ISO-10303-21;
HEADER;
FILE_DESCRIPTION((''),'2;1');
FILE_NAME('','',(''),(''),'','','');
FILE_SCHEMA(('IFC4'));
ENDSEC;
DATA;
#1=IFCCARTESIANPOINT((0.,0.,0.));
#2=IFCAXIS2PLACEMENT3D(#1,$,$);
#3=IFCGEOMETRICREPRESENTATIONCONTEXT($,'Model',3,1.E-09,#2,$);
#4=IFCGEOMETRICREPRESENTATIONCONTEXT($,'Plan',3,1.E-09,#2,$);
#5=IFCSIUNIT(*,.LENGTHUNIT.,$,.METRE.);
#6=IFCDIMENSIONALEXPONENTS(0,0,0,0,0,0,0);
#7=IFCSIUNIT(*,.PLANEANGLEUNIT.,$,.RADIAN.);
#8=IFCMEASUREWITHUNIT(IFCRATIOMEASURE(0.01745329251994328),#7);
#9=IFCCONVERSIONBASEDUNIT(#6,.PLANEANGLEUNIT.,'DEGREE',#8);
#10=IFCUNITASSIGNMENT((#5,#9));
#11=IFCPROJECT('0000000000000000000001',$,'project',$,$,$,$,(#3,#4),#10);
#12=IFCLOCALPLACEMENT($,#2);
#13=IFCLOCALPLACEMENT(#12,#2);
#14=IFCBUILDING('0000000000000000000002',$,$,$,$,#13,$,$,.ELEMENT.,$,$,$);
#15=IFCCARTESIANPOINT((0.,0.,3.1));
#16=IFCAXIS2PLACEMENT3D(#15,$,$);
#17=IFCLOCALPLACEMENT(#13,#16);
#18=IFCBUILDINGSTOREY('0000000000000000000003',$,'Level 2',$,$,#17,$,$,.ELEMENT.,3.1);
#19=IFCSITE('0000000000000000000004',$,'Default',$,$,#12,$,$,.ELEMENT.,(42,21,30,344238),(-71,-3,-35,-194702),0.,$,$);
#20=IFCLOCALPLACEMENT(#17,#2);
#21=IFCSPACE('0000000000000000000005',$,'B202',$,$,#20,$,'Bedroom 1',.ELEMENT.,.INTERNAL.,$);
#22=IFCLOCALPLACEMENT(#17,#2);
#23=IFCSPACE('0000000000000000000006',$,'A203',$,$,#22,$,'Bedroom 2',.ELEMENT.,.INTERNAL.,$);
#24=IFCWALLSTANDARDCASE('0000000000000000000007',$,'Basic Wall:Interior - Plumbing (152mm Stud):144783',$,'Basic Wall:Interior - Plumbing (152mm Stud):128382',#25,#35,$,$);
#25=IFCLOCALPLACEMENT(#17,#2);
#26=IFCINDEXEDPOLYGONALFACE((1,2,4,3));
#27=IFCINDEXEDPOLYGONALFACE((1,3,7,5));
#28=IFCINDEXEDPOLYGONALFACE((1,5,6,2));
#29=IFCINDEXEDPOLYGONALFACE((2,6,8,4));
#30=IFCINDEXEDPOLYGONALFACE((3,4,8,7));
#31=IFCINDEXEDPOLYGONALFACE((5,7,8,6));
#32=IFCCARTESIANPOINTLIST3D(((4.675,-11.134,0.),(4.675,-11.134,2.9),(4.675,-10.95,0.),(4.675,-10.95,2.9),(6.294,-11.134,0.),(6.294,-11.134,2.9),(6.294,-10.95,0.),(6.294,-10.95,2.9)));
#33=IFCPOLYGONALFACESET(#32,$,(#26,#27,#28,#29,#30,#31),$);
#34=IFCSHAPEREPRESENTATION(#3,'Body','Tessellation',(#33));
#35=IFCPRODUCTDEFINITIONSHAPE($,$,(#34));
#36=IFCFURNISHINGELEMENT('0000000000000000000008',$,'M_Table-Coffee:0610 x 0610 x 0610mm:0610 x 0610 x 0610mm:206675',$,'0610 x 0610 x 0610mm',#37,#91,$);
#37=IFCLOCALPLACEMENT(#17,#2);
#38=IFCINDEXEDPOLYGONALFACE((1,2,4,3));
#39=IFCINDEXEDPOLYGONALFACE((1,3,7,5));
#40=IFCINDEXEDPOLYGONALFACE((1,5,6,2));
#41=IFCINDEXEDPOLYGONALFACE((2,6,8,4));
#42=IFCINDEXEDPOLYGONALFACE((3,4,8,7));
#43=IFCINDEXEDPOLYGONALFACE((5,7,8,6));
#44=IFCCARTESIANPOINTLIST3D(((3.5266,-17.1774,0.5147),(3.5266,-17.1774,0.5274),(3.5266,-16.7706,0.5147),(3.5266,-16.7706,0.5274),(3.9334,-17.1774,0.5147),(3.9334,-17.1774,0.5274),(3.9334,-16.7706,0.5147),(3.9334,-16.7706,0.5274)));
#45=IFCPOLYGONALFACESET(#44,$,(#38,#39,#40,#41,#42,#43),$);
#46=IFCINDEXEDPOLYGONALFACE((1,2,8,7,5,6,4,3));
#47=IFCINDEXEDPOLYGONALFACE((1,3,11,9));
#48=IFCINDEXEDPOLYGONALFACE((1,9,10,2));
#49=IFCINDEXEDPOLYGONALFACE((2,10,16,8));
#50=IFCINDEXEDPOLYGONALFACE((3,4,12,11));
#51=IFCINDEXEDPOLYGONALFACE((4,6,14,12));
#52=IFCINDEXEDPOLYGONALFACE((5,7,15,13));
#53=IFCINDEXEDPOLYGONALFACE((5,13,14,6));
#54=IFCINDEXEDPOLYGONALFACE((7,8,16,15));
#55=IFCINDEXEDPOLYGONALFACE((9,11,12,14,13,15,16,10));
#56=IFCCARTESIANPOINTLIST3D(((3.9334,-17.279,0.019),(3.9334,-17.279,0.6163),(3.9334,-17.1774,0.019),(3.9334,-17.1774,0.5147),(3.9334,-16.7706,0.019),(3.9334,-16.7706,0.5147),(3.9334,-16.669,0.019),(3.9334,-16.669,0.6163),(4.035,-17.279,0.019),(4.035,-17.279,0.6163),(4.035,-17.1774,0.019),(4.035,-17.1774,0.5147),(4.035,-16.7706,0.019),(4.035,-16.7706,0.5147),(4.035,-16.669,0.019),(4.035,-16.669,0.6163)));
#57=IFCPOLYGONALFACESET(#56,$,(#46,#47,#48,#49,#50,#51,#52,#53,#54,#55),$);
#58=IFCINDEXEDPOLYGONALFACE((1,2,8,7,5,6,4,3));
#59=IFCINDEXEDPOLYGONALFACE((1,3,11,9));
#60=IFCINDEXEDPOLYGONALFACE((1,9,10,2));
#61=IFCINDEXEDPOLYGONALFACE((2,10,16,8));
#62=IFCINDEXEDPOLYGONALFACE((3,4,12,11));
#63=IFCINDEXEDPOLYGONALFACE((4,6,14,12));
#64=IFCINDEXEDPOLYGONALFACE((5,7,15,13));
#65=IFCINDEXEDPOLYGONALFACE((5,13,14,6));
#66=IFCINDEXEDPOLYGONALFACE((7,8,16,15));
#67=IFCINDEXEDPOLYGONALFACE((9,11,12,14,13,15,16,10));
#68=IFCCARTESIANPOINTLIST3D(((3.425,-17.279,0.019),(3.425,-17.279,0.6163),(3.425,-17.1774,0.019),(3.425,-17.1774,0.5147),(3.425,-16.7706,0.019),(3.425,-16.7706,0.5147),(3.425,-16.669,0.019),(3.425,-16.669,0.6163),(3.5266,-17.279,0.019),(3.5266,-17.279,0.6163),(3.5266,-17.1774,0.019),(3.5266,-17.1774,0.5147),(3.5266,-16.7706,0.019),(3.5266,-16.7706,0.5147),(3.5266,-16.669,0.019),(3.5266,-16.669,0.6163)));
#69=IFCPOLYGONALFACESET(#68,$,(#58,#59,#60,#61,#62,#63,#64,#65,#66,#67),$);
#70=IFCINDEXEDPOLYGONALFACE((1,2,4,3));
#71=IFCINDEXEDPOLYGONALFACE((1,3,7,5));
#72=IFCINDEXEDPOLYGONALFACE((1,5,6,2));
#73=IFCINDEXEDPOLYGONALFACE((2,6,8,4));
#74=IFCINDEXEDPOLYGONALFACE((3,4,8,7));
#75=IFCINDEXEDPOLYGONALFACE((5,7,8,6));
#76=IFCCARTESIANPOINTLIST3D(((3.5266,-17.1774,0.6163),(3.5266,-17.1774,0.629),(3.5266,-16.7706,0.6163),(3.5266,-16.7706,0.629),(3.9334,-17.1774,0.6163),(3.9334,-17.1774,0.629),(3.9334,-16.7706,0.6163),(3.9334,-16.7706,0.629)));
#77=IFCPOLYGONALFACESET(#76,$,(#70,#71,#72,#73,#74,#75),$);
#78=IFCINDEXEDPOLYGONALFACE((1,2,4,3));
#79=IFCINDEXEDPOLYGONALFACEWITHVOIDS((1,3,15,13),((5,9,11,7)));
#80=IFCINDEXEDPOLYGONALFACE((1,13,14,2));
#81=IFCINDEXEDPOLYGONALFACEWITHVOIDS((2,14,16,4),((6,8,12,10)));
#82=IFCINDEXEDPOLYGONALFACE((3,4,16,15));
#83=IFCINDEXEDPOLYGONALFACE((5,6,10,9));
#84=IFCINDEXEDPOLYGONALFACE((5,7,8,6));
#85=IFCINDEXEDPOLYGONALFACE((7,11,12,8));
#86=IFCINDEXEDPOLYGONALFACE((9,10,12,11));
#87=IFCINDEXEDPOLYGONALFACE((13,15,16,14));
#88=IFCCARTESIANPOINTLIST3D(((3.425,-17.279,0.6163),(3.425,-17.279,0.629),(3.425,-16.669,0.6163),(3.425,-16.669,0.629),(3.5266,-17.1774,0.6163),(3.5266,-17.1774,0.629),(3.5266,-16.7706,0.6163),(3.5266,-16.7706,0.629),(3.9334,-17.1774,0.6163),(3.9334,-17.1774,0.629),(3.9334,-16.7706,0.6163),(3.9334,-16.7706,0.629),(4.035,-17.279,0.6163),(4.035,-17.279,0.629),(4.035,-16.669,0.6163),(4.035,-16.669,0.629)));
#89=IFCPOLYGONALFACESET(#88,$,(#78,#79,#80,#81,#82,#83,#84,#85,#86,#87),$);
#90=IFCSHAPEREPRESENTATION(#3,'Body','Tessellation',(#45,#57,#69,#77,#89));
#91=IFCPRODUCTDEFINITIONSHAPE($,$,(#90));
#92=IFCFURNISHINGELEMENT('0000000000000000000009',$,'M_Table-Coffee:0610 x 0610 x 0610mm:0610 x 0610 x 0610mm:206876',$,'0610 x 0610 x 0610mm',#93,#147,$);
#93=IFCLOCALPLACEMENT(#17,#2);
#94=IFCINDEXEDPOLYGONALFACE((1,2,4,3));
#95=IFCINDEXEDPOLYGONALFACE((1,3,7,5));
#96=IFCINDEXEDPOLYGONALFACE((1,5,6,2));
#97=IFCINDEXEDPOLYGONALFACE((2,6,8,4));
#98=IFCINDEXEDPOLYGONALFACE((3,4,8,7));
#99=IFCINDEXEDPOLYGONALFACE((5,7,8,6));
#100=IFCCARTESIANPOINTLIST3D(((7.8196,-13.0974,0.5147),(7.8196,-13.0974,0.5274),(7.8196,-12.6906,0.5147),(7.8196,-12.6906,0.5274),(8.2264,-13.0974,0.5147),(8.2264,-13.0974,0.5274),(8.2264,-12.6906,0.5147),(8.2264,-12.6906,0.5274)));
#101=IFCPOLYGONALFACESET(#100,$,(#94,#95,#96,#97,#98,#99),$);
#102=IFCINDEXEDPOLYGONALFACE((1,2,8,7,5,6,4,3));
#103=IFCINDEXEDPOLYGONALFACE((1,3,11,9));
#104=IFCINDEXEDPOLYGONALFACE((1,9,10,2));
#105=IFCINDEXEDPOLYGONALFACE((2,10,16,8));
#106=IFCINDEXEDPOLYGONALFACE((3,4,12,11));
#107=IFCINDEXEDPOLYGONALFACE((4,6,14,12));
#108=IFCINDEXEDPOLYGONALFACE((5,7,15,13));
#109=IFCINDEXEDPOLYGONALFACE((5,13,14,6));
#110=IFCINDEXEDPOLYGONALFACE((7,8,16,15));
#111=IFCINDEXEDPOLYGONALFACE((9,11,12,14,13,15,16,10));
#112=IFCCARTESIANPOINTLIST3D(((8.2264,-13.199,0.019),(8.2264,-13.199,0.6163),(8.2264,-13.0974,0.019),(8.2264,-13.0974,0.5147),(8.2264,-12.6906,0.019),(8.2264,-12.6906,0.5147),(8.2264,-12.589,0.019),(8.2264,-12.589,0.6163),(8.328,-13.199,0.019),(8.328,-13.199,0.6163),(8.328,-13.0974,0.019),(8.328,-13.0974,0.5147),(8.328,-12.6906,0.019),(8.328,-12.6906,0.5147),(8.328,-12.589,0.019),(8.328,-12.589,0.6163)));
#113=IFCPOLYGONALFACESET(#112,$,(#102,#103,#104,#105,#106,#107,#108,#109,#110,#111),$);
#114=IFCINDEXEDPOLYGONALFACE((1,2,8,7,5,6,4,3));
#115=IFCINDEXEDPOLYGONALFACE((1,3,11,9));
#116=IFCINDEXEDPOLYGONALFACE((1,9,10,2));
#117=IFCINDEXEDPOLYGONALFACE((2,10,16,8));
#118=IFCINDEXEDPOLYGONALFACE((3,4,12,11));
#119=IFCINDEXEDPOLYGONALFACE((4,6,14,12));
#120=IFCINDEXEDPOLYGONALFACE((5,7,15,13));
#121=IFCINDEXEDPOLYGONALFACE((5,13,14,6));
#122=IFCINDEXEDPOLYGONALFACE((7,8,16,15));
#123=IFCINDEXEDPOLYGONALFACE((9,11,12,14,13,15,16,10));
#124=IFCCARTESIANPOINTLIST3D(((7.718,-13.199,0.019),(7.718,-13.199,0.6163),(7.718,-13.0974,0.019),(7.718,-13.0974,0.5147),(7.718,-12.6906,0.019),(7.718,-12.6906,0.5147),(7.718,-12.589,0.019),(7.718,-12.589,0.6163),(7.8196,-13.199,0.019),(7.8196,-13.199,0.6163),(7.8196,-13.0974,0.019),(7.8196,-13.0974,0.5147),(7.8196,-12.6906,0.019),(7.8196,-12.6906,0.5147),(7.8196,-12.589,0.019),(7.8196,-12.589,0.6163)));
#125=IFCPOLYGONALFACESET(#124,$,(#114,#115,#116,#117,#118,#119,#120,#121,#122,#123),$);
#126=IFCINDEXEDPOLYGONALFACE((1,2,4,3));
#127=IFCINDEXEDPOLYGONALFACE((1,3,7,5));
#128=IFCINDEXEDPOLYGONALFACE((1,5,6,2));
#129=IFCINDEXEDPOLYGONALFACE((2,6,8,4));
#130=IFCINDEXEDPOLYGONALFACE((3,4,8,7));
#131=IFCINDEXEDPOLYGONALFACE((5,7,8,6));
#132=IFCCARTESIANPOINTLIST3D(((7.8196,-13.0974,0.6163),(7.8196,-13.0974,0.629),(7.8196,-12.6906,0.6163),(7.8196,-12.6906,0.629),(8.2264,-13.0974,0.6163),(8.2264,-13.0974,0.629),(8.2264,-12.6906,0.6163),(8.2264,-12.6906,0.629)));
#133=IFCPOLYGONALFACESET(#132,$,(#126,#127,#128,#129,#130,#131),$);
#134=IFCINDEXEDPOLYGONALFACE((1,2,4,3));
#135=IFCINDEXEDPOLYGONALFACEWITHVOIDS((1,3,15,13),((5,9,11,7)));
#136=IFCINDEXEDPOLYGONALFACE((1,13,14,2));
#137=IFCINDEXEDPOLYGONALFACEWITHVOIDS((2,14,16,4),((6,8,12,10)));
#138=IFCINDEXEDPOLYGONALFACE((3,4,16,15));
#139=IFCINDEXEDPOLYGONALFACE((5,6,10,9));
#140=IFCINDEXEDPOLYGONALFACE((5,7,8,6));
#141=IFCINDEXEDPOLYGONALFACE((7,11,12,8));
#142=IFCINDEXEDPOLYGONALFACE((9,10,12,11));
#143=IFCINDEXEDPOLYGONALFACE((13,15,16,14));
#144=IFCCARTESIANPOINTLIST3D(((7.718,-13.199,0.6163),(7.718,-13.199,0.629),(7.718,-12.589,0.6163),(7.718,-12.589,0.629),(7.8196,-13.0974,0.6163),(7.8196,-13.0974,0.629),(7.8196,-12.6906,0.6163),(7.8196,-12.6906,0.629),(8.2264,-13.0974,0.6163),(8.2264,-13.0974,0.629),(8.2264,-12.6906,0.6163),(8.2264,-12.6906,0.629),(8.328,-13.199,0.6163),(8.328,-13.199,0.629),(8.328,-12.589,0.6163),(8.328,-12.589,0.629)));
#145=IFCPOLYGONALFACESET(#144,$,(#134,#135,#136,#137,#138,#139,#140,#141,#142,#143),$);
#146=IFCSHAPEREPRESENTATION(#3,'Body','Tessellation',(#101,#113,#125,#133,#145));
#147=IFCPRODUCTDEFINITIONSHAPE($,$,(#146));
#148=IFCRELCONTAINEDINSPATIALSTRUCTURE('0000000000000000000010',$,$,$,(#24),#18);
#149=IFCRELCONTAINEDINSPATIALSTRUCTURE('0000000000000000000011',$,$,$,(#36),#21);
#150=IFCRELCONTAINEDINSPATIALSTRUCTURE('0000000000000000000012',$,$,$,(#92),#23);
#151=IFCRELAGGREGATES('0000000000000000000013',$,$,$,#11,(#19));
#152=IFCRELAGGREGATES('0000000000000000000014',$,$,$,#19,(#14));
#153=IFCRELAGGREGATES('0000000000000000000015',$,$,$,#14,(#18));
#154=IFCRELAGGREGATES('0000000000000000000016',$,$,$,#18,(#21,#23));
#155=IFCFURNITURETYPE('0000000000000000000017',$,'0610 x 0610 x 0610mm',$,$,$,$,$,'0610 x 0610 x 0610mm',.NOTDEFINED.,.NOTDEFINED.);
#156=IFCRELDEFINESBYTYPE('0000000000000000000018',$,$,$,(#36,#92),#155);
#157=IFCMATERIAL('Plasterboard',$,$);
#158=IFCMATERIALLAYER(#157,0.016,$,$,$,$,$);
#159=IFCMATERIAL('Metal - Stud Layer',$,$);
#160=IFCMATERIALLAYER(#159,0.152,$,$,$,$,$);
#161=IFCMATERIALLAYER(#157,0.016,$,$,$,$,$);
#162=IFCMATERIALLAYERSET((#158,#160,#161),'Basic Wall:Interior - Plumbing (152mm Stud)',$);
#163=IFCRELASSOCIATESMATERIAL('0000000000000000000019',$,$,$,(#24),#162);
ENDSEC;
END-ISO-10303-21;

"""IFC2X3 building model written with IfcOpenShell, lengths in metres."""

from ifc_helpers import new_model, entity, si_unit, converted_unit, frame, frame_2d, origin, origin_2d_with_axis, place, context, project, spatial, polyline, rectangle, outline, extrude, source, transform, mapped, material, layer, layer_set, layer_usage, type_object, type_shapes, element, save


model = new_model("IFC2X3")

# Units and contexts
model_context = context("Model", 3, precision=1e-09, world=origin())
plan_context = context("Plan", 3, precision=1e-09, world=origin())
ifc_project = project(units=[si_unit("LENGTHUNIT", "METRE"), converted_unit("PLANEANGLEUNIT", "DEGREE", entity("IfcRatioMeasure", 0.01745329251994328), si_unit("PLANEANGLEUNIT", "RADIAN"), dimensions=[0, 0, 0, 0, 0, 0, 0])], contexts=[model_context, plan_context])

# Site, building, storey
site_placement = place(None, origin())
site = spatial("IfcSite", under=ifc_project, at=site_placement, Name="Default", CompositionType="ELEMENT", RefLatitude=(42, 21, 30, 344238), RefLongitude=(-71, -3, -35, -194702), RefElevation=0.0)
building_placement = place(site_placement, origin())
building = spatial("IfcBuilding", under=site, at=building_placement, CompositionType="ELEMENT")
storey_placement = place(building_placement, frame((0.0, 0.0, 3.1)))
storey = spatial("IfcBuildingStorey", under=building, at=storey_placement, Name="Level 2", CompositionType="ELEMENT", Elevation=3.1)

# Shared definitions
ifc_material_1 = material(Name="Metal - Stud Layer")
ifc_material_2 = material(Name="Plasterboard")

# Wall
ifc_layer_1 = layer(ifc_material_2, 0.016)
ifc_layer_2 = layer(ifc_material_1, 0.152)
ifc_layer_3 = layer(ifc_material_2, 0.016)
ifc_layer_set_1 = layer_set([ifc_layer_1, ifc_layer_2, ifc_layer_3], Name="Basic Wall:Interior - Plumbing (152mm Stud)")
ifc_layer_usage_1 = layer_usage(ifc_layer_set_1, "AXIS2", "NEGATIVE", 0.092)
wall_1_placement = place(storey_placement, frame((6.294, -11.042, 0.0), z_axis=(0.0, 0.0, 1.0), x_axis=(-1.0, 0.0, 0.0)))
element("IfcWallStandardCase", 1, at=wall_1_placement, inside=storey, material=ifc_layer_usage_1, Name="Basic Wall:Interior - Plumbing (152mm Stud):144783", ObjectType="Basic Wall:Interior - Plumbing (152mm Stud):128382", context=model_context, shape_type="SweptSolid", body=[
    extrude(rectangle(XDim=1.619, YDim=0.184, at=frame_2d((0.8095, 0.0), x_axis=(-1.0, 0.0))), origin(), (0.0, 0.0, 1.0), 2.9),
])

# Shared definitions
space_1_placement = place(storey_placement, origin())
space_1 = spatial("IfcSpace", under=storey, at=space_1_placement, Name="B202", LongName="Bedroom 1", CompositionType="ELEMENT", InteriorOrExteriorSpace="INTERNAL")

# Furnishing element
furniture_type = type_object("IfcFurnitureType", Name="0610 x 0610 x 0610mm", ElementType="0610 x 0610 x 0610mm", AssemblyPlace="NOTDEFINED")
shared_shape_1 = source(origin(), model_context, "Body", "SweptSolid", [
    extrude(rectangle(XDim=0.4068, YDim=0.4068, at=origin_2d_with_axis()), frame((0.0183, 0.0952, 0.4957), z_axis=(0.0, 0.0, 1.0), x_axis=(-1.0, 0.0, 0.0)), (0.0, 0.0, 1.0), 0.0127),
    extrude(outline(polyline([(-0.2732, -0.305), (0.324, -0.305), (0.324, 0.305), (-0.2732, 0.305), (-0.2732, 0.2034), (0.2225, 0.2034), (0.2225, -0.2034), (-0.2732, -0.2034), (-0.2732, -0.305)])), frame((0.2217, 0.0952, 0.2732), z_axis=(1.0, 0.0, 0.0), x_axis=(0.0, 0.0, 1.0)), (0.0, 0.0, 1.0), 0.1016),
    extrude(outline(polyline([(-0.305, -0.3241), (0.305, -0.3241), (0.305, 0.2733), (0.2034, 0.2733), (0.2034, -0.2224), (-0.2034, -0.2224), (-0.2034, 0.2733), (-0.305, 0.2733), (-0.305, -0.3241)])), frame((-0.2867, 0.0952, 0.2733), z_axis=(1.0, 0.0, 0.0), x_axis=(0.0, -1.0, 0.0)), (0.0, 0.0, 1.0), 0.1016),
    extrude(rectangle(XDim=0.4068, YDim=0.4068, at=origin_2d_with_axis()), frame((0.0183, 0.0952, 0.5973), z_axis=(0.0, 0.0, 1.0), x_axis=(-1.0, 0.0, 0.0)), (0.0, 0.0, 1.0), 0.0127),
    extrude(outline(polyline([(-0.305, -0.305), (0.305, -0.305), (0.305, 0.305), (-0.305, 0.305), (-0.305, -0.305)]), holes=[polyline([(-0.2034, -0.2034), (-0.2034, 0.2034), (0.2034, 0.2034), (0.2034, -0.2034), (-0.2034, -0.2034)])]), frame((0.0183, 0.0952, 0.5973), z_axis=(0.0, 0.0, 1.0), x_axis=(-1.0, 0.0, 0.0)), (0.0, 0.0, 1.0), 0.0127),
])
type_shapes(furniture_type, [shared_shape_1])
furnishing_1_placement = place(space_1_placement, frame((3.7117, -17.0692, 0.019)))
element("IfcFurnishingElement", 2, at=furnishing_1_placement, inside=space_1, type_object=furniture_type, Name="M_Table-Coffee:0610 x 0610 x 0610mm:0610 x 0610 x 0610mm:206675", ObjectType="0610 x 0610 x 0610mm", context=model_context, shape_type="MappedRepresentation", body=[
    mapped(shared_shape_1, transform((0.0, 0.0, 0.0), scale=1.0)),
])

# Shared definitions
space_2_placement = place(storey_placement, origin())
space_2 = spatial("IfcSpace", under=storey, at=space_2_placement, Name="A203", LongName="Bedroom 2", CompositionType="ELEMENT", InteriorOrExteriorSpace="INTERNAL")

# Furnishing element
furnishing_2_placement = place(space_2_placement, frame((8.0047, -12.9892, 0.019)))
element("IfcFurnishingElement", 3, at=furnishing_2_placement, inside=space_2, type_object=furniture_type, Name="M_Table-Coffee:0610 x 0610 x 0610mm:0610 x 0610 x 0610mm:206876", ObjectType="0610 x 0610 x 0610mm", context=model_context, shape_type="MappedRepresentation", body=[
    mapped(shared_shape_1, transform((0.0, 0.0, 0.0), scale=1.0)),
])

save(model, "model.ifc")
